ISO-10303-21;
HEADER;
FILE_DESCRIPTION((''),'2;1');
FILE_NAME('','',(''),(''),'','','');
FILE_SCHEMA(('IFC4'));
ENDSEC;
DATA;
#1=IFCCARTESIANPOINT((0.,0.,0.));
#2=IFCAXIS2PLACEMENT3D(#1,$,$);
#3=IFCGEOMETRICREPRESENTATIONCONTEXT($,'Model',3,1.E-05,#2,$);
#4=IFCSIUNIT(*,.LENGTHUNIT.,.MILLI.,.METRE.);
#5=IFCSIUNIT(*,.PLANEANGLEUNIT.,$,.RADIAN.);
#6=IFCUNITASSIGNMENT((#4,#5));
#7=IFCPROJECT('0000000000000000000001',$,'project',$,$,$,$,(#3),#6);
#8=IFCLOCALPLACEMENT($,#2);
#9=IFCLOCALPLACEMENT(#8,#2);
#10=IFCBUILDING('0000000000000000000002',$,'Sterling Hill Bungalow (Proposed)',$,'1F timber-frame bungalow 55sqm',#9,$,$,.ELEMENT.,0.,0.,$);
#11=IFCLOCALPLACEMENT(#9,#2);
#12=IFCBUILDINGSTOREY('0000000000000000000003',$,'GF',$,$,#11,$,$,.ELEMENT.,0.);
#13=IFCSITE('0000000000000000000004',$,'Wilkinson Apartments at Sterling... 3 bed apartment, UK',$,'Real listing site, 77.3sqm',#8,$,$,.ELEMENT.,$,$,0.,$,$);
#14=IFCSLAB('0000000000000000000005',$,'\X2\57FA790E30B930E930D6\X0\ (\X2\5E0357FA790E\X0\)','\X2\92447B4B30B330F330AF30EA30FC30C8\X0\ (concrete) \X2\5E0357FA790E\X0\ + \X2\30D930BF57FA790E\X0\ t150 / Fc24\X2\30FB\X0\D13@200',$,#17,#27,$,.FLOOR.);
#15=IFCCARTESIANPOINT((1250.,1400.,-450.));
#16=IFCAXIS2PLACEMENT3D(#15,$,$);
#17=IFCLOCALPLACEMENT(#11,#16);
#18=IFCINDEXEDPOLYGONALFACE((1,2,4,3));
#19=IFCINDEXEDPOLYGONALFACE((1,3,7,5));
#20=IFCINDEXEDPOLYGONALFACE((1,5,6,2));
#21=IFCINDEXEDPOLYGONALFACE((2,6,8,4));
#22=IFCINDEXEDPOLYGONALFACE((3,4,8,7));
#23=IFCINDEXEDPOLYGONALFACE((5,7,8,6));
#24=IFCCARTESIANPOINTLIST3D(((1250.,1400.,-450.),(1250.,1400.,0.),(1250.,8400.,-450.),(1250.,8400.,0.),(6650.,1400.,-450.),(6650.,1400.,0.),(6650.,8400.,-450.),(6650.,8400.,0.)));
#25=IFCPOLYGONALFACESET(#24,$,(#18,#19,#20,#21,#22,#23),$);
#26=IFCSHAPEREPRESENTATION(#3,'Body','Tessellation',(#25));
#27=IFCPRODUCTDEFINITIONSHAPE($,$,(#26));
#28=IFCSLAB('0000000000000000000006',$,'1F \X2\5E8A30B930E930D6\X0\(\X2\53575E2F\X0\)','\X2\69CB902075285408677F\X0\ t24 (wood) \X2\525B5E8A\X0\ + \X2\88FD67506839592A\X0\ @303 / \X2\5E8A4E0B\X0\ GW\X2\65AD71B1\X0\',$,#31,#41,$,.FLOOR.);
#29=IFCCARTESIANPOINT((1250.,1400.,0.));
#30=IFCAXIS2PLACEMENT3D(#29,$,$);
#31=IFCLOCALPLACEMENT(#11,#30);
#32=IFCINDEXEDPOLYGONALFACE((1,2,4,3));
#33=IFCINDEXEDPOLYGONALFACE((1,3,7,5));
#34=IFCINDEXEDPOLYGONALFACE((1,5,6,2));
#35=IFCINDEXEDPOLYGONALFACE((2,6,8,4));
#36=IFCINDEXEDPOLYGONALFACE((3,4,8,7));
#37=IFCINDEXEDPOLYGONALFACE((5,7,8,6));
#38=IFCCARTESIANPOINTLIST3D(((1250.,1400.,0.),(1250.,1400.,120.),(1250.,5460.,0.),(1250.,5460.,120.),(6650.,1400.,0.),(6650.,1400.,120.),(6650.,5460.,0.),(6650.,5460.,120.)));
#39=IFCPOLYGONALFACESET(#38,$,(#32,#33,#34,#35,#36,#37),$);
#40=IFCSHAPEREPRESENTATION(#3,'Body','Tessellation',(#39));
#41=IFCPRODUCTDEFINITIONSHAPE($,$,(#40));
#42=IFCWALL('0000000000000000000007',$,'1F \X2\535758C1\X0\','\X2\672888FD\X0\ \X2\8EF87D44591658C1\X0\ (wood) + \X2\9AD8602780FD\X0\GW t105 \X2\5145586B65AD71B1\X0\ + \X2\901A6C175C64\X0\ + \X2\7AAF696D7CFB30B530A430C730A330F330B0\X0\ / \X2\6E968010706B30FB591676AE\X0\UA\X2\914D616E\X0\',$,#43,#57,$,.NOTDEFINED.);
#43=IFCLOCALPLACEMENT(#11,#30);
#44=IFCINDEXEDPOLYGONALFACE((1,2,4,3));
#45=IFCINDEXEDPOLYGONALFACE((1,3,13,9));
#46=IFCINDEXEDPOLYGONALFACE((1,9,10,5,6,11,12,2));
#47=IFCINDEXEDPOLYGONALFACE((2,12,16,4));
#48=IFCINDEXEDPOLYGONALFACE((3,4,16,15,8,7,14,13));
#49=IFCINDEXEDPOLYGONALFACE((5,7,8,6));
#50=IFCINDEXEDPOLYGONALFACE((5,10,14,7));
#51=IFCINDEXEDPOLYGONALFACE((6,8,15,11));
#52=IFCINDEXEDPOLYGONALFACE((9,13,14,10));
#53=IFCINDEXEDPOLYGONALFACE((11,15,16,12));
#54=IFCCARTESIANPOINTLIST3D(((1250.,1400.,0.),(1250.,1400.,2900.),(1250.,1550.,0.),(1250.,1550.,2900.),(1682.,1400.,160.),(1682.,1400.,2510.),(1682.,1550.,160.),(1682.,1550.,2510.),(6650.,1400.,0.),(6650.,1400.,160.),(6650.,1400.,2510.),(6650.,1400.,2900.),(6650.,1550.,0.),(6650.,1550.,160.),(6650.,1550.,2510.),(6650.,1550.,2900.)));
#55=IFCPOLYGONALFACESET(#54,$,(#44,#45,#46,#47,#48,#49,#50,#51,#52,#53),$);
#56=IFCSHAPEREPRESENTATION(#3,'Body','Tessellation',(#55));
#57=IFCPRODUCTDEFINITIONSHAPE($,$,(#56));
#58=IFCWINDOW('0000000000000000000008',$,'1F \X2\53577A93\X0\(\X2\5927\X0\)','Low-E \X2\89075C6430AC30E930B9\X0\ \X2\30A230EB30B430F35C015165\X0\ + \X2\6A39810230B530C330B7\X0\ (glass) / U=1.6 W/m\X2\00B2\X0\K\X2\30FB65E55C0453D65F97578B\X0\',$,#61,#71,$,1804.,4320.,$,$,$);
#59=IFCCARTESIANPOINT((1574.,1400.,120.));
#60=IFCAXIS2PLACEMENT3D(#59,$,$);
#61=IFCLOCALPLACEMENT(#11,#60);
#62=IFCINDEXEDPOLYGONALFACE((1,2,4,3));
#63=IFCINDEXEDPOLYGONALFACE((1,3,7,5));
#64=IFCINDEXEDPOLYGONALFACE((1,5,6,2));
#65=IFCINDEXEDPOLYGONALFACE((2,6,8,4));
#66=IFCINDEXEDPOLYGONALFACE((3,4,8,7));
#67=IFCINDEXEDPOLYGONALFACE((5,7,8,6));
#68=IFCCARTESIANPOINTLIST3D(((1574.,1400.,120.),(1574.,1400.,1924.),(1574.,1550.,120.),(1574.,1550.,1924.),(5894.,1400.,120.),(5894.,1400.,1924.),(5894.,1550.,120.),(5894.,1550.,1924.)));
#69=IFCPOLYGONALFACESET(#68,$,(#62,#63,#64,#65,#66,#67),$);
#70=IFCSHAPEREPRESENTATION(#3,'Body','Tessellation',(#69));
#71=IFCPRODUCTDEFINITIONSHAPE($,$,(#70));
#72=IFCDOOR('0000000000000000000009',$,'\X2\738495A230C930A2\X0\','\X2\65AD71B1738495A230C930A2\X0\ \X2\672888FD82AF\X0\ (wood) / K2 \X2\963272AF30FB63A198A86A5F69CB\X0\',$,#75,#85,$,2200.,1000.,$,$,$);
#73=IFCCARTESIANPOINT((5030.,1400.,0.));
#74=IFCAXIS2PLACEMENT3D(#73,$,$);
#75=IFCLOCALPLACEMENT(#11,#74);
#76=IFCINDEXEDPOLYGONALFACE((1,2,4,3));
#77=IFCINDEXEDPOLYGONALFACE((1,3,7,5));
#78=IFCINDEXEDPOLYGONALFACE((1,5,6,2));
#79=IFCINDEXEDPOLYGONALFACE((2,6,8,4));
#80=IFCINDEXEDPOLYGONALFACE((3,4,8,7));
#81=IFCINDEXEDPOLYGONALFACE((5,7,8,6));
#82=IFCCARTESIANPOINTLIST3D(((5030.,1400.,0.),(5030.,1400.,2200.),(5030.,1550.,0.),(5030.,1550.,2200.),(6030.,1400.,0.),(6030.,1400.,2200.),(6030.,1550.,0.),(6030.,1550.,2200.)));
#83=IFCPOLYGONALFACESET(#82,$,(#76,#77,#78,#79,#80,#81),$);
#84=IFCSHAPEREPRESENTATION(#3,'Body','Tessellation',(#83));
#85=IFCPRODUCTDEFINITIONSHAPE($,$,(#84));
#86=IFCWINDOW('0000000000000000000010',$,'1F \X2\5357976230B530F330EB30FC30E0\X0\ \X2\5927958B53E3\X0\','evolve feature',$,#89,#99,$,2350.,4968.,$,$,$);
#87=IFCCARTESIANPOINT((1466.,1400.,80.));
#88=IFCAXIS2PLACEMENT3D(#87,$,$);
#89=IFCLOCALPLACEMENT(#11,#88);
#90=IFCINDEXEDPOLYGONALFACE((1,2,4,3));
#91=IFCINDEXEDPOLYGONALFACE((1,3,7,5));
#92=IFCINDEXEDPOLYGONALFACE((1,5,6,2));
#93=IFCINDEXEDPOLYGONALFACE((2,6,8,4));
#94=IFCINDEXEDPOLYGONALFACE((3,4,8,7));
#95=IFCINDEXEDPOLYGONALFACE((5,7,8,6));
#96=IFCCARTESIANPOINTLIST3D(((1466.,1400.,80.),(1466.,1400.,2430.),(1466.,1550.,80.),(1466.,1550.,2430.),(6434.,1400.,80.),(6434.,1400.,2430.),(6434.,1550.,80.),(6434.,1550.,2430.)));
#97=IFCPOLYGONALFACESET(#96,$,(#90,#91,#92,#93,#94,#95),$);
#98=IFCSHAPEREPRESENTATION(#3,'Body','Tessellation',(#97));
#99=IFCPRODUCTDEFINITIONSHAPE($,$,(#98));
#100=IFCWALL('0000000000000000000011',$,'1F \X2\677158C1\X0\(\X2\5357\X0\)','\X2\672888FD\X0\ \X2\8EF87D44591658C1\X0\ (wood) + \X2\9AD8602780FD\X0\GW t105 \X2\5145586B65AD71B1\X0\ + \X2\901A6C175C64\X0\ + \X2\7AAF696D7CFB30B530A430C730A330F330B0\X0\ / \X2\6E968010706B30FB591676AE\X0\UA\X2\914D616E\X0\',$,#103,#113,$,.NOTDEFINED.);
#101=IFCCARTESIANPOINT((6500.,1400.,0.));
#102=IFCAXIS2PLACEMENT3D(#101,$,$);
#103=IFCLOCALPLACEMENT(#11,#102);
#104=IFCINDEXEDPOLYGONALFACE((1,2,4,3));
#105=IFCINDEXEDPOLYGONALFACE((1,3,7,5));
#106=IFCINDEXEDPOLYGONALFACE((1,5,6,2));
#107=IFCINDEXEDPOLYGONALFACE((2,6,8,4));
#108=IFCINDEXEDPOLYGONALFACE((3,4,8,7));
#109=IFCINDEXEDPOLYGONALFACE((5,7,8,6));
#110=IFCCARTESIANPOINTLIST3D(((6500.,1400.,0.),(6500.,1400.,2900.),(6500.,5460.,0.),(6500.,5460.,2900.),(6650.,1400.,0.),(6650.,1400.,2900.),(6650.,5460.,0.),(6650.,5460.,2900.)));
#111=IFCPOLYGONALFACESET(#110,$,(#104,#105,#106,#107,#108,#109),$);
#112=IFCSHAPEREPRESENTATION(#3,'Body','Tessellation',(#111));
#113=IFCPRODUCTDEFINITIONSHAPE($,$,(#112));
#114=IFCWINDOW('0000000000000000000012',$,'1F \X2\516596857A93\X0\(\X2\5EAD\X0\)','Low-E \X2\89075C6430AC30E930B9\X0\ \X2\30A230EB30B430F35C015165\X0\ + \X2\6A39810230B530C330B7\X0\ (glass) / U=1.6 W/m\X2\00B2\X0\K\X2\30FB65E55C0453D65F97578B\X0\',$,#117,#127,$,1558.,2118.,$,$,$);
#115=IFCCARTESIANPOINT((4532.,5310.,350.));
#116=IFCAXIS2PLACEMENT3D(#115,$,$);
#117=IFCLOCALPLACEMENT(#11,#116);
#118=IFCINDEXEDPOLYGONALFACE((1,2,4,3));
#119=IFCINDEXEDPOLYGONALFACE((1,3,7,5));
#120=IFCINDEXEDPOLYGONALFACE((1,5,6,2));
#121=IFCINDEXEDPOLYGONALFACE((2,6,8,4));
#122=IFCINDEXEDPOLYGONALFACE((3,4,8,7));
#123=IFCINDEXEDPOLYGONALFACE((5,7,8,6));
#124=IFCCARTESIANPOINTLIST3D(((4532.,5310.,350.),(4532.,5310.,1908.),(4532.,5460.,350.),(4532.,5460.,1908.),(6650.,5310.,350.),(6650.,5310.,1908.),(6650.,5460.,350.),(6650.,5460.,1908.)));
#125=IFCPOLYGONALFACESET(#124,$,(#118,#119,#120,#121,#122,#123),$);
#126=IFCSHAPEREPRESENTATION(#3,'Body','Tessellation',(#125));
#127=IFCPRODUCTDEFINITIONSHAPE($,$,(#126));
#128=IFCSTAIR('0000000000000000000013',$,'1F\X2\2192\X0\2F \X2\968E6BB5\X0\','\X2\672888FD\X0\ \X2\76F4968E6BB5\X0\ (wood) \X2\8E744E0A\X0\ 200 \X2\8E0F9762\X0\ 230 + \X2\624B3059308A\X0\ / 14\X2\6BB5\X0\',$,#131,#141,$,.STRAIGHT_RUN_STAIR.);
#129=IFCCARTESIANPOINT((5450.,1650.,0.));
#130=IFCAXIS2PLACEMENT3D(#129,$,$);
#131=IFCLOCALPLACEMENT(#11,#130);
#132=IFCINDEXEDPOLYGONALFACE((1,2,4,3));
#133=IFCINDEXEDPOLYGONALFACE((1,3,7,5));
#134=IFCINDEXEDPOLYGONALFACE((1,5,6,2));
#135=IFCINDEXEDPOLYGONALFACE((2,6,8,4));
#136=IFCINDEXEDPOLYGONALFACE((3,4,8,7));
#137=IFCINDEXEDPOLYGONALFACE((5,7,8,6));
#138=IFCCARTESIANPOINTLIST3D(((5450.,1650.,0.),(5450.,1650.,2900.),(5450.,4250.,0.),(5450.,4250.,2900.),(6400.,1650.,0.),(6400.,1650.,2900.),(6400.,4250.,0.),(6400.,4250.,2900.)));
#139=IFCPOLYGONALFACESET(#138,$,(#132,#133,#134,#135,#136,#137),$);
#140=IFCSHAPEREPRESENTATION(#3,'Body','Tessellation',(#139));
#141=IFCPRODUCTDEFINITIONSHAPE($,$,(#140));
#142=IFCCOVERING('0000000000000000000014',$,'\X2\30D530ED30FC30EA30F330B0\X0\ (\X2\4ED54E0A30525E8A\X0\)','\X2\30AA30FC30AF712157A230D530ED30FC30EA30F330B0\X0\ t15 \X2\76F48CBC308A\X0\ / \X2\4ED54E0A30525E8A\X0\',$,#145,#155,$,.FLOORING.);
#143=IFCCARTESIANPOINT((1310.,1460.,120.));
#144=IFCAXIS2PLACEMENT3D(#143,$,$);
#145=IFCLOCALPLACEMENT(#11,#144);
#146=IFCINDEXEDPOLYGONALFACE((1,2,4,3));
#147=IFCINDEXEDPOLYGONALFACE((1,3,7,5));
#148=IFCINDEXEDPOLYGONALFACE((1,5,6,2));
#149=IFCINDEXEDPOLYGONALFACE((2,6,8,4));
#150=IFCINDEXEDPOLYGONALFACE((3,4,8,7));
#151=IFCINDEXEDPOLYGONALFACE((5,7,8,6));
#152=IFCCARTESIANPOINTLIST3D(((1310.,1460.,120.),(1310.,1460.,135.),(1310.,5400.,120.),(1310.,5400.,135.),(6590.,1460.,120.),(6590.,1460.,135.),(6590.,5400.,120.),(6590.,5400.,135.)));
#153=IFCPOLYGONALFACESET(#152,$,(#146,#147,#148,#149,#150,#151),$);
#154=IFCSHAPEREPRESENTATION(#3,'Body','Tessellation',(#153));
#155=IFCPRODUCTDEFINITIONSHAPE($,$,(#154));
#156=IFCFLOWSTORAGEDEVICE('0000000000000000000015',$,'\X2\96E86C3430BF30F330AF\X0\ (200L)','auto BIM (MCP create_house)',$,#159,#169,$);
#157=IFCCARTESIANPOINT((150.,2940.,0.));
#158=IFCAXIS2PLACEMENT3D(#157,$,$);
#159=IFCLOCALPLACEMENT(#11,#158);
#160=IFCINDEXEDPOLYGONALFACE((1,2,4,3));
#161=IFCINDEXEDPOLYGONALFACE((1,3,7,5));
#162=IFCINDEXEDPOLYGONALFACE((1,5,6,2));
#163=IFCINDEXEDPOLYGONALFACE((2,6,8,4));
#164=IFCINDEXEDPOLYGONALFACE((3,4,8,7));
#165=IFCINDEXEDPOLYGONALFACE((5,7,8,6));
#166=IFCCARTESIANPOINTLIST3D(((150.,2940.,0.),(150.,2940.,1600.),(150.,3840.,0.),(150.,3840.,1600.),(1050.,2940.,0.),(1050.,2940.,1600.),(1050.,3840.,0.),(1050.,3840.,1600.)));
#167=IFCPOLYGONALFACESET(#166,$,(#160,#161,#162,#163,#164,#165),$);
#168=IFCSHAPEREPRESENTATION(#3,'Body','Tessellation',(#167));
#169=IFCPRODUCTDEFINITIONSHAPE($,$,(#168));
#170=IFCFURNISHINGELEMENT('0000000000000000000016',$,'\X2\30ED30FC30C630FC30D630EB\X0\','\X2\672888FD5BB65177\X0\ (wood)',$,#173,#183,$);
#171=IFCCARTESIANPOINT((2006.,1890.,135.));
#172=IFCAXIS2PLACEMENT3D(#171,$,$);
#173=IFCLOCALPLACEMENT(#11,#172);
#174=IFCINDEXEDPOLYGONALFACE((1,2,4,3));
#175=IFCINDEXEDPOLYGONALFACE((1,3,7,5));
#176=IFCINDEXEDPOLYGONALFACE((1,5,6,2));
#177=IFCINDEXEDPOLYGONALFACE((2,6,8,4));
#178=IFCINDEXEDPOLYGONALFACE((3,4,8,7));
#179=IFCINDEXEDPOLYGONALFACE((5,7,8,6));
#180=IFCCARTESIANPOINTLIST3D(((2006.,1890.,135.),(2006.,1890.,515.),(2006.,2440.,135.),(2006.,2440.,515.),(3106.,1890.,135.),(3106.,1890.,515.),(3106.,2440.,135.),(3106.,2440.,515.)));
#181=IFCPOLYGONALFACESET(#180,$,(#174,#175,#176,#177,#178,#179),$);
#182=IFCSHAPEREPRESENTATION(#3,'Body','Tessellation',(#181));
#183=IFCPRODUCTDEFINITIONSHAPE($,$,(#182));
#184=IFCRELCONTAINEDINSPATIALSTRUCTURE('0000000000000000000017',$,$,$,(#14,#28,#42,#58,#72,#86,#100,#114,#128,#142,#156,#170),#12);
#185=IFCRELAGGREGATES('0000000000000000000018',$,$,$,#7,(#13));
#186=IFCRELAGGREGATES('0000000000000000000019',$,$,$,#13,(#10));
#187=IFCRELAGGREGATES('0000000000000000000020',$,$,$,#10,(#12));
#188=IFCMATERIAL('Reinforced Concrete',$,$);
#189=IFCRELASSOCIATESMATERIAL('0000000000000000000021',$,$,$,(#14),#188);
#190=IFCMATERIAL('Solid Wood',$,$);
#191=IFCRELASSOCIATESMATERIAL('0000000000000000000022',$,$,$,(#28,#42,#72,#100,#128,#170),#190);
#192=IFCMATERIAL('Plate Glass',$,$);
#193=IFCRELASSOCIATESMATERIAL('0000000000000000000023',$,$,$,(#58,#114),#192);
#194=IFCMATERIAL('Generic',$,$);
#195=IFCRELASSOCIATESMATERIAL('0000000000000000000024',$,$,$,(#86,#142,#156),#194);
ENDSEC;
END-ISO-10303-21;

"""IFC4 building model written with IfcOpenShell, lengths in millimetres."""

from ifc_helpers import new_model, si_unit, frame, frame_2d, origin, place, context, project, spatial, rectangle, extrude, material, element, fill, save


model = new_model("IFC4")

# Units and contexts
model_context = context("Model", 3, precision=1e-05, world=origin())
ifc_project = project(units=[si_unit("LENGTHUNIT", "METRE", prefix="MILLI"), si_unit("PLANEANGLEUNIT", "RADIAN")], contexts=[model_context])

# Site, building, storey
site_placement = place(None, origin())
site = spatial("IfcSite", under=ifc_project, at=site_placement, Name="Wilkinson Apartments at Sterling... 3 bed apartment, UK", ObjectType="Real listing site, 77.3sqm", CompositionType="ELEMENT", RefElevation=0.0)
building_placement = place(site_placement, origin())
building = spatial("IfcBuilding", under=site, at=building_placement, Name="Sterling Hill Bungalow (Proposed)", ObjectType="1F timber-frame bungalow 55sqm", CompositionType="ELEMENT", ElevationOfRefHeight=0.0, ElevationOfTerrain=0.0)
storey_placement = place(building_placement, origin())
storey = spatial("IfcBuildingStorey", under=building, at=storey_placement, Name="GF", CompositionType="ELEMENT", Elevation=0.0)

# Slabs
ifc_material_1 = material(Name="Reinforced Concrete")
slab_1_placement = place(storey_placement, frame((1250.0, 1400.0, -450.0)))
element("IfcSlab", 1, at=slab_1_placement, inside=storey, material=ifc_material_1, Name="基礎スラブ (布基礎)", Description="鉄筋コンクリート (concrete) 布基礎 + ベタ基礎 t150 / Fc24・D13@200", PredefinedType="FLOOR", context=model_context, shape_type="SweptSolid", body=[
    extrude(rectangle(XDim=5400.0, YDim=7000.0, at=frame_2d((2700.0, 3500.0))), frame((1250.0, 1400.0, -450.0)), (0.0, 0.0, 1.0), 450.0),
])
ifc_material_2 = material(Name="Solid Wood")
slab_2_placement = place(storey_placement, frame((1250.0, 1400.0, 0.0)))
element("IfcSlab", 2, at=slab_2_placement, inside=storey, material=ifc_material_2, Name="1F 床スラブ(南帯)", Description="構造用合板 t24 (wood) 剛床 + 製材根太 @303 / 床下 GW断熱", PredefinedType="FLOOR", context=model_context, shape_type="SweptSolid", body=[
    extrude(rectangle(XDim=5400.0, YDim=4060.0, at=frame_2d((2700.0, 2030.0))), frame((1250.0, 1400.0, 0.0)), (0.0, 0.0, 1.0), 120.0),
])

# Wall, openings, windows, door
wall_1_placement = place(storey_placement, frame((1250.0, 1400.0, 0.0)))
wall_1 = element("IfcWall", 3, at=wall_1_placement, inside=storey, material=ifc_material_2, Name="1F 南壁", Description="木製 軸組外壁 (wood) + 高性能GW t105 充填断熱 + 通気層 + 窯業系サイディング / 準耐火・外皮UA配慮", PredefinedType="NOTDEFINED", context=model_context, shape_type="SweptSolid", body=[
    extrude(rectangle(XDim=5400.0, YDim=150.0, at=frame_2d((2700.0, 75.0))), frame((1250.0, 1400.0, 0.0)), (0.0, 0.0, 1.0), 2900.0),
])
opening_1_placement = place(storey_placement, frame((1574.0, 1400.0, 120.0)))
opening_1 = element("IfcOpeningElement", 4, at=opening_1_placement, cuts=wall_1, PredefinedType="NOTDEFINED", context=model_context, shape_type="SweptSolid", body=[
    extrude(rectangle(XDim=4320.0, YDim=150.0, at=frame_2d((2160.0, 75.0))), frame((1574.0, 1400.0, 120.0)), (0.0, 0.0, 1.0), 1804.0),
])
opening_2_placement = place(storey_placement, frame((5030.0, 1400.0, 0.0)))
opening_2 = element("IfcOpeningElement", 5, at=opening_2_placement, cuts=wall_1, PredefinedType="NOTDEFINED", context=model_context, shape_type="SweptSolid", body=[
    extrude(rectangle(XDim=1000.0, YDim=150.0, at=frame_2d((500.0, 75.0))), frame((5030.0, 1400.0, 0.0)), (0.0, 0.0, 1.0), 2200.0),
])
opening_3_placement = place(storey_placement, frame((1466.0, 1400.0, 80.0)))
opening_3 = element("IfcOpeningElement", 6, at=opening_3_placement, cuts=wall_1, PredefinedType="NOTDEFINED", context=model_context, shape_type="SweptSolid", body=[
    extrude(rectangle(XDim=4968.0, YDim=150.0, at=frame_2d((2484.0, 75.0))), frame((1466.0, 1400.0, 80.0)), (0.0, 0.0, 1.0), 2350.0),
])
ifc_material_3 = material(Name="Plate Glass")
window_1_placement = place(storey_placement, frame((1574.0, 1400.0, 120.0)))
window_1 = element("IfcWindow", 7, at=window_1_placement, inside=storey, material=ifc_material_3, Name="1F 南窓(大)", Description="Low-E 複層ガラス アルゴン封入 + 樹脂サッシ (glass) / U=1.6 W/m²K・日射取得型", OverallHeight=1804.0, OverallWidth=4320.0, context=model_context, shape_type="SweptSolid", body=[
    extrude(rectangle(XDim=4320.0, YDim=150.0, at=frame_2d((2160.0, 75.0))), frame((1574.0, 1400.0, 120.0)), (0.0, 0.0, 1.0), 1804.0),
])
fill(opening_1, window_1)
door_1_placement = place(storey_placement, frame((5030.0, 1400.0, 0.0)))
door_1 = element("IfcDoor", 8, at=door_1_placement, inside=storey, material=ifc_material_2, Name="玄関ドア", Description="断熱玄関ドア 木製芯 (wood) / K2 防犯・採風機構", OverallHeight=2200.0, OverallWidth=1000.0, context=model_context, shape_type="SweptSolid", body=[
    extrude(rectangle(XDim=1000.0, YDim=150.0, at=frame_2d((500.0, 75.0))), frame((5030.0, 1400.0, 0.0)), (0.0, 0.0, 1.0), 2200.0),
])
fill(opening_2, door_1)
ifc_material_4 = material(Name="Generic")
window_2_placement = place(storey_placement, frame((1466.0, 1400.0, 80.0)))
window_2 = element("IfcWindow", 9, at=window_2_placement, inside=storey, material=ifc_material_4, Name="1F 南面サンルーム 大開口", Description="evolve feature", OverallHeight=2350.0, OverallWidth=4968.0, context=model_context, shape_type="SweptSolid", body=[
    extrude(rectangle(XDim=4968.0, YDim=150.0, at=frame_2d((2484.0, 75.0))), frame((1466.0, 1400.0, 80.0)), (0.0, 0.0, 1.0), 2350.0),
])
fill(opening_3, window_2)

# Wall, opening, window
wall_2_placement = place(storey_placement, frame((6500.0, 1400.0, 0.0)))
wall_2 = element("IfcWall", 10, at=wall_2_placement, inside=storey, material=ifc_material_2, Name="1F 東壁(南)", Description="木製 軸組外壁 (wood) + 高性能GW t105 充填断熱 + 通気層 + 窯業系サイディング / 準耐火・外皮UA配慮", PredefinedType="NOTDEFINED", context=model_context, shape_type="SweptSolid", body=[
    extrude(rectangle(XDim=150.0, YDim=4060.0, at=frame_2d((75.0, 2030.0))), frame((6500.0, 1400.0, 0.0)), (0.0, 0.0, 1.0), 2900.0),
])
opening_4_placement = place(storey_placement, frame((4532.0, 5310.0, 350.0)))
opening_4 = element("IfcOpeningElement", 11, at=opening_4_placement, cuts=wall_2, PredefinedType="NOTDEFINED", context=model_context, shape_type="SweptSolid", body=[
    extrude(rectangle(XDim=2118.0, YDim=150.0, at=frame_2d((1059.0, 75.0))), frame((4532.0, 5310.0, 350.0)), (0.0, 0.0, 1.0), 1558.0),
])
window_3_placement = place(storey_placement, frame((4532.0, 5310.0, 350.0)))
window_3 = element("IfcWindow", 12, at=window_3_placement, inside=storey, material=ifc_material_3, Name="1F 入隅窓(庭)", Description="Low-E 複層ガラス アルゴン封入 + 樹脂サッシ (glass) / U=1.6 W/m²K・日射取得型", OverallHeight=1558.0, OverallWidth=2118.0, context=model_context, shape_type="SweptSolid", body=[
    extrude(rectangle(XDim=2118.0, YDim=150.0, at=frame_2d((1059.0, 75.0))), frame((4532.0, 5310.0, 350.0)), (0.0, 0.0, 1.0), 1558.0),
])
fill(opening_4, window_3)

# Stair
stair_placement = place(storey_placement, frame((5450.0, 1650.0, 0.0)))
element("IfcStair", 13, at=stair_placement, inside=storey, material=ifc_material_2, Name="1F→2F 階段", Description="木製 直階段 (wood) 蹴上 200 踏面 230 + 手すり / 14段", PredefinedType="STRAIGHT_RUN_STAIR", context=model_context, shape_type="SweptSolid", body=[
    extrude(rectangle(XDim=950.0, YDim=2600.0, at=frame_2d((475.0, 1300.0))), frame((5450.0, 1650.0, 0.0)), (0.0, 0.0, 1.0), 2900.0),
])

# Covering
covering_placement = place(storey_placement, frame((1310.0, 1460.0, 120.0)))
element("IfcCovering", 14, at=covering_placement, inside=storey, material=ifc_material_4, Name="フローリング (仕上げ床)", Description="オーク無垢フローリング t15 直貼り / 仕上げ床", PredefinedType="FLOORING", context=model_context, shape_type="SweptSolid", body=[
    extrude(rectangle(XDim=5280.0, YDim=3940.0, at=frame_2d((2640.0, 1970.0))), frame((1310.0, 1460.0, 120.0)), (0.0, 0.0, 1.0), 15.0),
])

# Flow storage device
flow_storage_device_placement = place(storey_placement, frame((150.0, 2940.0, 0.0)))
element("IfcFlowStorageDevice", 15, at=flow_storage_device_placement, inside=storey, material=ifc_material_4, Name="雨水タンク (200L)", Description="auto BIM (MCP create_house)", context=model_context, shape_type="SweptSolid", body=[
    extrude(rectangle(XDim=900.0, YDim=900.0, at=frame_2d((450.0, 450.0))), frame((150.0, 2940.0, 0.0)), (0.0, 0.0, 1.0), 1600.0),
])

# Furnishing element
furnishing_1_placement = place(storey_placement, frame((2006.0, 1890.0, 135.0)))
element("IfcFurnishingElement", 16, at=furnishing_1_placement, inside=storey, material=ifc_material_2, Name="ローテーブル", Description="木製家具 (wood)", context=model_context, shape_type="SweptSolid", body=[
    extrude(rectangle(XDim=1100.0, YDim=550.0, at=frame_2d((550.0, 275.0))), frame((2006.0, 1890.0, 135.0)), (0.0, 0.0, 1.0), 380.0),
])

save(model, "model.ifc")
